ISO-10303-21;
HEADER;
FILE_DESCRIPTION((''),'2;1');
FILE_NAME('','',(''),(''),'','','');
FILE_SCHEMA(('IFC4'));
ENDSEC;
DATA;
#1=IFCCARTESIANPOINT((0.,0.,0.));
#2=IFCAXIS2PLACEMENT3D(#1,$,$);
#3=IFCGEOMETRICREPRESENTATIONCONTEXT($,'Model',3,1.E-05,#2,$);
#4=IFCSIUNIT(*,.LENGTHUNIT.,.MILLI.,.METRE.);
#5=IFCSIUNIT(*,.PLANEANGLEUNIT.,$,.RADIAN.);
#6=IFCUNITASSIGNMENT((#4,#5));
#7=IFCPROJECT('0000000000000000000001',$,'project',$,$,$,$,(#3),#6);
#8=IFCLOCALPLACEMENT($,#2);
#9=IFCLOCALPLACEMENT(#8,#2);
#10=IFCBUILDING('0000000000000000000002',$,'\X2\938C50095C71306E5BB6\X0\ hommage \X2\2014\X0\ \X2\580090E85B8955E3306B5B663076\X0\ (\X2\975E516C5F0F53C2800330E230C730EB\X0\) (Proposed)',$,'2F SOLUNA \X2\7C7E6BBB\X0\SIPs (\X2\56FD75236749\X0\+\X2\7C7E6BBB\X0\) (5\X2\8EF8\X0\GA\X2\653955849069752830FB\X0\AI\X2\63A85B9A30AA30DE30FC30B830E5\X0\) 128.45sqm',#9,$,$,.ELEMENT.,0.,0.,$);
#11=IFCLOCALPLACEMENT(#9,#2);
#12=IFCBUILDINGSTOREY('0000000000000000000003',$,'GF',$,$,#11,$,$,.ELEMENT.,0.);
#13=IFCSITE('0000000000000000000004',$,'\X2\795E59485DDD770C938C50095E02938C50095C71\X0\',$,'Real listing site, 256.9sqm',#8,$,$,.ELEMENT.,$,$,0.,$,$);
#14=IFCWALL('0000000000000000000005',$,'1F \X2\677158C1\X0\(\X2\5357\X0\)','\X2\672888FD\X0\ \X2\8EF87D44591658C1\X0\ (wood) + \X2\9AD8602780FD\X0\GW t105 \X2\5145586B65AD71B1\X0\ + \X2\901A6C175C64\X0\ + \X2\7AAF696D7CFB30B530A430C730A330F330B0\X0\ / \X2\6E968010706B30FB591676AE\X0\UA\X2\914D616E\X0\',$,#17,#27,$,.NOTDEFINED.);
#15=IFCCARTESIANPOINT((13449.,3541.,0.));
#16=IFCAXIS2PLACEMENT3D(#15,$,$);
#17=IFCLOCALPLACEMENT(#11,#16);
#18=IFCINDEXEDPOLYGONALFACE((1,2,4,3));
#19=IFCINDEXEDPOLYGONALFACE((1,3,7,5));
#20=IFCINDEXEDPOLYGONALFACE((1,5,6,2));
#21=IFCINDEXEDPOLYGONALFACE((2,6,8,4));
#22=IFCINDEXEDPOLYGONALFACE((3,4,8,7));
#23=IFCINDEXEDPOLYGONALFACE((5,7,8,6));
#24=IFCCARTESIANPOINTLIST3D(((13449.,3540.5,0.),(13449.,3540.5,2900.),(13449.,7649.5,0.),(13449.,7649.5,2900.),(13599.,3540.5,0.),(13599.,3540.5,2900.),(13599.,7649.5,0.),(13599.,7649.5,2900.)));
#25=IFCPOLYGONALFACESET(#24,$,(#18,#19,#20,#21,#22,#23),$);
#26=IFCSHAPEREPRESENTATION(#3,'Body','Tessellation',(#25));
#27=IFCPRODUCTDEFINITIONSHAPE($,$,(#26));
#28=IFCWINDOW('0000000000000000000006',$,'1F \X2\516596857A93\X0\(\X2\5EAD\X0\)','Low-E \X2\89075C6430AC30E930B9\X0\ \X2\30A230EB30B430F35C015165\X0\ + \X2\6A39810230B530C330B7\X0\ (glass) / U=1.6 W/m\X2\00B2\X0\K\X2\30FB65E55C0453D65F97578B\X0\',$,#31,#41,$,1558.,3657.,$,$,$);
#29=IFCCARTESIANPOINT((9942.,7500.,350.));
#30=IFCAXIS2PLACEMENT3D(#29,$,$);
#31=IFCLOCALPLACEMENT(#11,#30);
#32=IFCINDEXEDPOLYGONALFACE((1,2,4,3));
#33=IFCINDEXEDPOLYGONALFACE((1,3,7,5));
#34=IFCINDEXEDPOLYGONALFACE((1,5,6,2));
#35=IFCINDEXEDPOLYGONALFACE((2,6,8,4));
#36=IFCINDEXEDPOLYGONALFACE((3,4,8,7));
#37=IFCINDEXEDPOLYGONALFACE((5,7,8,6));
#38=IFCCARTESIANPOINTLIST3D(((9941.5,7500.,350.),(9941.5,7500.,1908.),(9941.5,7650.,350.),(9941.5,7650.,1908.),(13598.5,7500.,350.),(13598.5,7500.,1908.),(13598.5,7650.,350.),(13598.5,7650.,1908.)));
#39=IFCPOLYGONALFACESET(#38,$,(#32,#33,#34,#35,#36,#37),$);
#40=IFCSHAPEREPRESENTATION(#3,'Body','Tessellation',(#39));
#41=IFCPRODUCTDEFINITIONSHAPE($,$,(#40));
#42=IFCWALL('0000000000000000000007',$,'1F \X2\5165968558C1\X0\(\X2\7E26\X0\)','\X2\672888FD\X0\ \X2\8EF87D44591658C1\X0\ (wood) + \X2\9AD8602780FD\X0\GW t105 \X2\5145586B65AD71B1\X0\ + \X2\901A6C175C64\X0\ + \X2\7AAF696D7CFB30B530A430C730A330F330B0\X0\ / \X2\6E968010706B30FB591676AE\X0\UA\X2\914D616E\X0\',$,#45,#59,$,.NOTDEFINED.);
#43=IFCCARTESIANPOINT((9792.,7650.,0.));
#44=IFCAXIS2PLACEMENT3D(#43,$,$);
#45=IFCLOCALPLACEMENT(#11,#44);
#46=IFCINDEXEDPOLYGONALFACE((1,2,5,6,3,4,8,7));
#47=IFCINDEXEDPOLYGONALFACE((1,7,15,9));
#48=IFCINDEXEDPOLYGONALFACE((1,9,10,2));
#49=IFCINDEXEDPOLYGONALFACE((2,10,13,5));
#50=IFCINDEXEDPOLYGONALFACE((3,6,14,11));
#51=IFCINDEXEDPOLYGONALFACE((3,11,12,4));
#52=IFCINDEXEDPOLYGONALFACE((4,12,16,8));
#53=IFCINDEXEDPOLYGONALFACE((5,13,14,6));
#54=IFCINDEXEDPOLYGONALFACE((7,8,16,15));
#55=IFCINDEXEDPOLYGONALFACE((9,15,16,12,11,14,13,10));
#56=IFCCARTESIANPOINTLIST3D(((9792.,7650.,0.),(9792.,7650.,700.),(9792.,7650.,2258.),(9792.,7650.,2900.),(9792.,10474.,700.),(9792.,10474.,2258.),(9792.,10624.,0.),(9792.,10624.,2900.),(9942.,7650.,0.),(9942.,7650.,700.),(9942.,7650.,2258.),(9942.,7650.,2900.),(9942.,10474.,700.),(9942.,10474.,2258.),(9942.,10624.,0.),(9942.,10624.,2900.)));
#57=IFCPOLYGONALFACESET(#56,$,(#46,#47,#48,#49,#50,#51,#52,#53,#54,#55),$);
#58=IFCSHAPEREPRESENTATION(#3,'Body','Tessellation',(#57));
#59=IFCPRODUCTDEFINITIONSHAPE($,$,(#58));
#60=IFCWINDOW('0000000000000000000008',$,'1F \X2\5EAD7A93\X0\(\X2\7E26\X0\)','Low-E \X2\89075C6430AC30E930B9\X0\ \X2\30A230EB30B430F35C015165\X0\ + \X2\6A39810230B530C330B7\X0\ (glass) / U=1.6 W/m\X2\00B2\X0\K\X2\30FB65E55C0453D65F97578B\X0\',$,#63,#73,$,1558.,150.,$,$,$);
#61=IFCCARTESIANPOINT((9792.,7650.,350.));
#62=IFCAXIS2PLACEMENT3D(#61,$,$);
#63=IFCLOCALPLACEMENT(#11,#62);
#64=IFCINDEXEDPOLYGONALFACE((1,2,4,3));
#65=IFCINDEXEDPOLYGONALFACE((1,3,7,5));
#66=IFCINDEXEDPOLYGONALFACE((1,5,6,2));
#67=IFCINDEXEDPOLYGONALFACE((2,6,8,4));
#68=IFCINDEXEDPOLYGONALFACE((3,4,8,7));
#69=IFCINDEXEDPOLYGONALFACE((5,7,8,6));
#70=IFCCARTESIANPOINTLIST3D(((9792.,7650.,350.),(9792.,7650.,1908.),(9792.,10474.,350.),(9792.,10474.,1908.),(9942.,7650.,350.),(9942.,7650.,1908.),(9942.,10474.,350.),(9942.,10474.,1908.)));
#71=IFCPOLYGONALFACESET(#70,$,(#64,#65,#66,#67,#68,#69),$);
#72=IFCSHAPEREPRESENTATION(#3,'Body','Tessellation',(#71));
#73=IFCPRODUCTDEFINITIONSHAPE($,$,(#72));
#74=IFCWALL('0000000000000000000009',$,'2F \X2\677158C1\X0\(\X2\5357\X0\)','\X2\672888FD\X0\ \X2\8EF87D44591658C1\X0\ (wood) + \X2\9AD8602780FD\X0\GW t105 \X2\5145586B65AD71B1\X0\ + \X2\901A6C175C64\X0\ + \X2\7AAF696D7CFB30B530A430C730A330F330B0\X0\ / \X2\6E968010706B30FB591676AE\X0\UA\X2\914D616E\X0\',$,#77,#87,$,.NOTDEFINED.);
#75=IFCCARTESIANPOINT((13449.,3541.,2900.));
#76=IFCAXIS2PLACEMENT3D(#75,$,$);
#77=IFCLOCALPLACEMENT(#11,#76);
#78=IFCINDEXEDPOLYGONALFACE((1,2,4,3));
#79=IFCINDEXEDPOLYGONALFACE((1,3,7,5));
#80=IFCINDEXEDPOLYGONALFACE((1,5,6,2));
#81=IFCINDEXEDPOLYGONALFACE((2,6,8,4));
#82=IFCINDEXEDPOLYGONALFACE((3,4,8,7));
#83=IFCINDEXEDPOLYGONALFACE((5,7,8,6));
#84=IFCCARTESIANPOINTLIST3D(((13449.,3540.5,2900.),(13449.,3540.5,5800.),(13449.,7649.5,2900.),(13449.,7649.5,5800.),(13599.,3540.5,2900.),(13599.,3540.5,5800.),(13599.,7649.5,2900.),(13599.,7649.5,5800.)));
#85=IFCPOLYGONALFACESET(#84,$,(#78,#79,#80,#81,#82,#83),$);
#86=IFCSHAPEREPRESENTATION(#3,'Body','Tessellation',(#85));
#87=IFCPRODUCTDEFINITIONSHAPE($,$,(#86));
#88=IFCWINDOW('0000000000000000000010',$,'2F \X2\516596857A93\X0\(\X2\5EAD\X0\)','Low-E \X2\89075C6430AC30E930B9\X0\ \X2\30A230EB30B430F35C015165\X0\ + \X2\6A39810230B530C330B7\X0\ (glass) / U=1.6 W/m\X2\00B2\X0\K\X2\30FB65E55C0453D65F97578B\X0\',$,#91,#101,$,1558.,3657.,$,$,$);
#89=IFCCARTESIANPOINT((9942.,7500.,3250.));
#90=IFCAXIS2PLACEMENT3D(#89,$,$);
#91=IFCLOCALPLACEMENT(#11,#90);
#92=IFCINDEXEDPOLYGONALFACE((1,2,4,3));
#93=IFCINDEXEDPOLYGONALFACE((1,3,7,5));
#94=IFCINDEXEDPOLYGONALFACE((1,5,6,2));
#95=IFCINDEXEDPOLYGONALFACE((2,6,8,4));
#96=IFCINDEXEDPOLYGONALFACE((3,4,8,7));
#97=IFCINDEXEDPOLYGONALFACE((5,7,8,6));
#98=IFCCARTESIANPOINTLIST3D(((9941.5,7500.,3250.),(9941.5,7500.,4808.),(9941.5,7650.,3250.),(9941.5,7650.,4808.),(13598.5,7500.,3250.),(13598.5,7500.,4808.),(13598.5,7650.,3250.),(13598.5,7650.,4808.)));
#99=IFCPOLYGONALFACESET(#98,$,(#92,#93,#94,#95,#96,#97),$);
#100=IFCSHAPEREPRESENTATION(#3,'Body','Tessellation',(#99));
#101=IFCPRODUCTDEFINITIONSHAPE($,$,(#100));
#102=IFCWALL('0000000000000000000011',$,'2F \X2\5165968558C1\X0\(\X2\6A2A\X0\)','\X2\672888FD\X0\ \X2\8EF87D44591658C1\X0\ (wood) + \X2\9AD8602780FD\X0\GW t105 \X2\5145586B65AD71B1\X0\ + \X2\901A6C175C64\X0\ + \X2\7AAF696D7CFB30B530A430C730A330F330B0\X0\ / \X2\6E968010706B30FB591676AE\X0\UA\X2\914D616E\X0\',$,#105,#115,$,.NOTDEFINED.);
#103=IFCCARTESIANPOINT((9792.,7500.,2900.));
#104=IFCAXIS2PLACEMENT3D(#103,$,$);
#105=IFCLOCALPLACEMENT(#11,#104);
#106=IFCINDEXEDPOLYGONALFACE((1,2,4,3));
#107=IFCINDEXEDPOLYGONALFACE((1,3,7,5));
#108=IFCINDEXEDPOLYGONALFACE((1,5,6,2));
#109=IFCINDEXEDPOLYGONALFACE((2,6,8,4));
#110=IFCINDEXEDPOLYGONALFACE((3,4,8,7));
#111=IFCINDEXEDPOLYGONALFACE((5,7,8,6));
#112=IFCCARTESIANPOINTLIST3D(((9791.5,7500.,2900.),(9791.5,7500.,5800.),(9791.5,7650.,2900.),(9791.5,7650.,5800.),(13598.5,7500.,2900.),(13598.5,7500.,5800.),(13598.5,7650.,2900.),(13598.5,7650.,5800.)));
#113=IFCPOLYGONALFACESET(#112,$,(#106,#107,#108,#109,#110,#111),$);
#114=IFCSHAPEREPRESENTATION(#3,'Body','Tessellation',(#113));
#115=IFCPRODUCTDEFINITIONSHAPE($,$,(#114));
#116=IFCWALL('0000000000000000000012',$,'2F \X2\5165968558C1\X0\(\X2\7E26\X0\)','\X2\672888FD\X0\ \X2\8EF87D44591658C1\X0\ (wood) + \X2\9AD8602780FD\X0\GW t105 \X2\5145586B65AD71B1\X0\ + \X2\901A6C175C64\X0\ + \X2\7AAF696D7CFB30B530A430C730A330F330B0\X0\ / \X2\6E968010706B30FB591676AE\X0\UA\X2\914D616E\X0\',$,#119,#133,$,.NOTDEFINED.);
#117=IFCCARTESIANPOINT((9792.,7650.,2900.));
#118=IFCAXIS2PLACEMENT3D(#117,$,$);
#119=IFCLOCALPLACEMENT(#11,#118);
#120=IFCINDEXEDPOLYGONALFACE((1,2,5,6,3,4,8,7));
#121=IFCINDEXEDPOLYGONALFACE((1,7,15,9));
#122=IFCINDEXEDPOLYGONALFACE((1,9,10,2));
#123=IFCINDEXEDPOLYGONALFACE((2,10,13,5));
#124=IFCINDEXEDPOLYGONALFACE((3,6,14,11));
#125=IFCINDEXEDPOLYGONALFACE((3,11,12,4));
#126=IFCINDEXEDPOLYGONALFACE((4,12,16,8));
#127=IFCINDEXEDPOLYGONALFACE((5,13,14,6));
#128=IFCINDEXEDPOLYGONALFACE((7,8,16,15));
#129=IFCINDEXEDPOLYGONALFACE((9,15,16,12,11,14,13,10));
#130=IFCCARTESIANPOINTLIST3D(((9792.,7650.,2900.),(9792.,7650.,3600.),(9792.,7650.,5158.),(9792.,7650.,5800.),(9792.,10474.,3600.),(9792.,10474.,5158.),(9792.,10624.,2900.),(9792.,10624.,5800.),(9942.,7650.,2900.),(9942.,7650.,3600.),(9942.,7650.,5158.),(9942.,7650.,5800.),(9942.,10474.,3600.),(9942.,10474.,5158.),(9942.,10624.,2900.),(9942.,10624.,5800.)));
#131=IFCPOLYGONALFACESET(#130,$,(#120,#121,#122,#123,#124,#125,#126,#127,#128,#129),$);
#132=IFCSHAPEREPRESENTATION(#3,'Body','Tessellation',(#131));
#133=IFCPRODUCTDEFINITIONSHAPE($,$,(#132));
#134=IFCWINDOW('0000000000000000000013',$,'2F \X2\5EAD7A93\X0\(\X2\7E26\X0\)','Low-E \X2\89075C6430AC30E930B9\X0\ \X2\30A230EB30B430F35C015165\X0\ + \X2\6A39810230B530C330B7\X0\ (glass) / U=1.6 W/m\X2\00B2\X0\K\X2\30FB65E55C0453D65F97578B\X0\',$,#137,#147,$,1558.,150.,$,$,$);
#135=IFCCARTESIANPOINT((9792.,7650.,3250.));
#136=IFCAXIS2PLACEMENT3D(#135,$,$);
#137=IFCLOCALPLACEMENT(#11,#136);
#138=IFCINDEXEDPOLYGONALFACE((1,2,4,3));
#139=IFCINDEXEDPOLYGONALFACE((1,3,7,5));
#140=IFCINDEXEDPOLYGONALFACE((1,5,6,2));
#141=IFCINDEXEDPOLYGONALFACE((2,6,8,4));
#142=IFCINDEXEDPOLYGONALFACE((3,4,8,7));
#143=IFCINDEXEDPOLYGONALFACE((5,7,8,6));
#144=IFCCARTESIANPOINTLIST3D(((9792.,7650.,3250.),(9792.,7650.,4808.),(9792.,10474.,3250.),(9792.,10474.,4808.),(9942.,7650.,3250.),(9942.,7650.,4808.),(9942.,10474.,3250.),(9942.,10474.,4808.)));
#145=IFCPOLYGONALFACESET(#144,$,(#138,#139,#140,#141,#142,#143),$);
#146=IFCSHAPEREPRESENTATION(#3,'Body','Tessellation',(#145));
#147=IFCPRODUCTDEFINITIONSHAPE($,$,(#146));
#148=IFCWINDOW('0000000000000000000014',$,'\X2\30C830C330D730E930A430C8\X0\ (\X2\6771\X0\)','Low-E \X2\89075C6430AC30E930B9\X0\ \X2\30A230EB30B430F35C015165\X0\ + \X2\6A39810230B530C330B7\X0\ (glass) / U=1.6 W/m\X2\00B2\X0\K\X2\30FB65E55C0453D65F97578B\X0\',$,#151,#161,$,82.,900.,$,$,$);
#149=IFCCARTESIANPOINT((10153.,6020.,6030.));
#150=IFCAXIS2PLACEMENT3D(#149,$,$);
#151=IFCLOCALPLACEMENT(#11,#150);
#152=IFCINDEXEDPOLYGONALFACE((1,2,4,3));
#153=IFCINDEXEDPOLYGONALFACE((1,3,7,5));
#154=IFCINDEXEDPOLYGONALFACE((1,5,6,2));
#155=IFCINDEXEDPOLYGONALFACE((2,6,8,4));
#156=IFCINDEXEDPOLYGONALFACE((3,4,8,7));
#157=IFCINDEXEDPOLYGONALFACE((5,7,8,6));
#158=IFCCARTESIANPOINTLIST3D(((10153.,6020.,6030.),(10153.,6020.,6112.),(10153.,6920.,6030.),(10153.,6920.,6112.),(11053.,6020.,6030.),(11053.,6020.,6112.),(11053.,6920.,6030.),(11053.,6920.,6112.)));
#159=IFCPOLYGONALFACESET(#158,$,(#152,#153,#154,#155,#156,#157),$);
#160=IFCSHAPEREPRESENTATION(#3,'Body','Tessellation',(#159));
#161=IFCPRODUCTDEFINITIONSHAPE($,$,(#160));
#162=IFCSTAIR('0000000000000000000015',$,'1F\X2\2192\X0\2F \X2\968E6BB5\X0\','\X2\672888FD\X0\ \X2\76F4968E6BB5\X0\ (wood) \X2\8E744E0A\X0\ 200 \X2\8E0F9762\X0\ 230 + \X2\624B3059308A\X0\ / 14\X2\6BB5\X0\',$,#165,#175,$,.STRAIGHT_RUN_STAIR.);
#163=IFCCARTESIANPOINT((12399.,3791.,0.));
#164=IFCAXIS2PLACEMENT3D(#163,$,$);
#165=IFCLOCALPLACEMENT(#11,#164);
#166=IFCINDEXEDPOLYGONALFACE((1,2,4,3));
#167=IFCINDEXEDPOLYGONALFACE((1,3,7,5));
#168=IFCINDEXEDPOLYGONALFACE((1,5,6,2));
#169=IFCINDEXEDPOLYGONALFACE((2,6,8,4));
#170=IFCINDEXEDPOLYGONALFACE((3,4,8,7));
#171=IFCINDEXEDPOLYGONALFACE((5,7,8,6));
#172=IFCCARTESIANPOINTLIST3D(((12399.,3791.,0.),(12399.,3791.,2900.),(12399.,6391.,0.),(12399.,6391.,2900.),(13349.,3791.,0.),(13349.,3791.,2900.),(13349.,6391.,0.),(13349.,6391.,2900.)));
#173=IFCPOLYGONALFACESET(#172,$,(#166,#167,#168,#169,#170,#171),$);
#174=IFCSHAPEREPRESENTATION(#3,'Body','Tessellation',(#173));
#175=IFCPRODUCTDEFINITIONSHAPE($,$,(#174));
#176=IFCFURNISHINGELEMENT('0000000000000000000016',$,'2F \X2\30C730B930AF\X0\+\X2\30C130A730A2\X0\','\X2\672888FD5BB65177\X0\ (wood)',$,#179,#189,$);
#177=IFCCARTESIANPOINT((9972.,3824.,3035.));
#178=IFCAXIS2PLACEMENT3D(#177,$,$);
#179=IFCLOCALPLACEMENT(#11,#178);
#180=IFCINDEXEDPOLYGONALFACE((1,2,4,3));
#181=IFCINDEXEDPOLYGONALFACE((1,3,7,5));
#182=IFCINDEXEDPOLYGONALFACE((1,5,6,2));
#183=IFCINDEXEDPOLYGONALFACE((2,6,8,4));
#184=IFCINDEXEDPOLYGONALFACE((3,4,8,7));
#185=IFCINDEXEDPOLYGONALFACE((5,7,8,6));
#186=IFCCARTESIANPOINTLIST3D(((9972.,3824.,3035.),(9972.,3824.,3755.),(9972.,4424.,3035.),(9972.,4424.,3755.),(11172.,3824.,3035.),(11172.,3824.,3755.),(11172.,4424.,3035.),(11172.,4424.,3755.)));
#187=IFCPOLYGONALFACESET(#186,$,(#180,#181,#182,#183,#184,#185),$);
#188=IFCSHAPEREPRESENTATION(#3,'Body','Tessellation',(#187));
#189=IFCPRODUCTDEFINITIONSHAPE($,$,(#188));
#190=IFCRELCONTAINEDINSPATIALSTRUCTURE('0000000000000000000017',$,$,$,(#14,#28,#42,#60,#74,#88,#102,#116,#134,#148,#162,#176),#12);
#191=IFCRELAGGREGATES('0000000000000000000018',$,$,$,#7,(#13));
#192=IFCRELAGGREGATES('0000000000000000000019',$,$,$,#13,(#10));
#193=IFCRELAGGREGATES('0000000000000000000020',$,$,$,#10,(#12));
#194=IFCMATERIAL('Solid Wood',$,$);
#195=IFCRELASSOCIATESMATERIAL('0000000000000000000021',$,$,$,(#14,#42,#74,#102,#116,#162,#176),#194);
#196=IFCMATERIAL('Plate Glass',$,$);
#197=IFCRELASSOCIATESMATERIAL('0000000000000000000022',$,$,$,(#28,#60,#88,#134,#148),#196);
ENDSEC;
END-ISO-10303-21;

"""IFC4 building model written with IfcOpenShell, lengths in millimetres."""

from ifc_helpers import new_model, si_unit, frame, frame_2d, origin, place, context, project, spatial, rectangle, extrude, material, element, fill, save


model = new_model("IFC4")

# Units and contexts
model_context = context("Model", 3, precision=1e-05, world=origin())
ifc_project = project(units=[si_unit("LENGTHUNIT", "METRE", prefix="MILLI"), si_unit("PLANEANGLEUNIT", "RADIAN")], contexts=[model_context])

# Site, building, storey
site_placement = place(None, origin())
site = spatial("IfcSite", under=ifc_project, at=site_placement, Name="神奈川県鎌倉市鎌倉山", ObjectType="Real listing site, 256.9sqm", CompositionType="ELEMENT", RefElevation=0.0)
building_placement = place(site_placement, origin())
building = spatial("IfcBuilding", under=site, at=building_placement, Name="鎌倉山の家 hommage — 堀部安嗣に学ぶ (非公式参考モデル) (Proposed)", ObjectType="2F SOLUNA 籾殻SIPs (国産杉+籾殻) (5軸GA改善適用・AI推定オマージュ) 128.45sqm", CompositionType="ELEMENT", ElevationOfRefHeight=0.0, ElevationOfTerrain=0.0)
storey_placement = place(building_placement, origin())
storey = spatial("IfcBuildingStorey", under=building, at=storey_placement, Name="GF", CompositionType="ELEMENT", Elevation=0.0)

# Shared definitions
ifc_material_1 = material(Name="Solid Wood")

# Wall, opening, window
wall_1_placement = place(storey_placement, frame((13449.0, 3541.0, 0.0)))
wall_1 = element("IfcWall", 1, at=wall_1_placement, inside=storey, material=ifc_material_1, Name="1F 東壁(南)", Description="木製 軸組外壁 (wood) + 高性能GW t105 充填断熱 + 通気層 + 窯業系サイディング / 準耐火・外皮UA配慮", PredefinedType="NOTDEFINED", context=model_context, shape_type="SweptSolid", body=[
    extrude(rectangle(XDim=150.0, YDim=4109.0, at=frame_2d((75.0, 2054.0))), frame((13449.0, 3541.0, 0.0)), (0.0, 0.0, 1.0), 2900.0),
])
opening_1_placement = place(storey_placement, frame((9942.0, 7500.0, 350.0)))
opening_1 = element("IfcOpeningElement", 2, at=opening_1_placement, cuts=wall_1, PredefinedType="NOTDEFINED", context=model_context, shape_type="SweptSolid", body=[
    extrude(rectangle(XDim=3657.0, YDim=150.0, at=frame_2d((1828.0, 75.0))), frame((9942.0, 7500.0, 350.0)), (0.0, 0.0, 1.0), 1558.0),
])
ifc_material_2 = material(Name="Plate Glass")
window_1_placement = place(storey_placement, frame((9942.0, 7500.0, 350.0)))
window_1 = element("IfcWindow", 3, at=window_1_placement, inside=storey, material=ifc_material_2, Name="1F 入隅窓(庭)", Description="Low-E 複層ガラス アルゴン封入 + 樹脂サッシ (glass) / U=1.6 W/m²K・日射取得型", OverallHeight=1558.0, OverallWidth=3657.0, context=model_context, shape_type="SweptSolid", body=[
    extrude(rectangle(XDim=3657.0, YDim=150.0, at=frame_2d((1828.0, 75.0))), frame((9942.0, 7500.0, 350.0)), (0.0, 0.0, 1.0), 1558.0),
])
fill(opening_1, window_1)

# Wall, opening, window
wall_2_placement = place(storey_placement, frame((9792.0, 7650.0, 0.0)))
wall_2 = element("IfcWall", 4, at=wall_2_placement, inside=storey, material=ifc_material_1, Name="1F 入隅壁(縦)", Description="木製 軸組外壁 (wood) + 高性能GW t105 充填断熱 + 通気層 + 窯業系サイディング / 準耐火・外皮UA配慮", PredefinedType="NOTDEFINED", context=model_context, shape_type="SweptSolid", body=[
    extrude(rectangle(XDim=150.0, YDim=2974.0, at=frame_2d((75.0, 1487.0))), frame((9792.0, 7650.0, 0.0)), (0.0, 0.0, 1.0), 2900.0),
])
opening_2_placement = place(storey_placement, frame((9792.0, 7650.0, 350.0)))
opening_2 = element("IfcOpeningElement", 5, at=opening_2_placement, cuts=wall_2, PredefinedType="NOTDEFINED", context=model_context, shape_type="SweptSolid", body=[
    extrude(rectangle(XDim=150.0, YDim=2824.0, at=frame_2d((75.0, 1412.0))), frame((9792.0, 7650.0, 350.0)), (0.0, 0.0, 1.0), 1558.0),
])
window_2_placement = place(storey_placement, frame((9792.0, 7650.0, 350.0)))
window_2 = element("IfcWindow", 6, at=window_2_placement, inside=storey, material=ifc_material_2, Name="1F 庭窓(縦)", Description="Low-E 複層ガラス アルゴン封入 + 樹脂サッシ (glass) / U=1.6 W/m²K・日射取得型", OverallHeight=1558.0, OverallWidth=150.0, context=model_context, shape_type="SweptSolid", body=[
    extrude(rectangle(XDim=150.0, YDim=2824.0, at=frame_2d((75.0, 1412.0))), frame((9792.0, 7650.0, 350.0)), (0.0, 0.0, 1.0), 1558.0),
])
fill(opening_2, window_2)

# Wall, opening, window
wall_3_placement = place(storey_placement, frame((13449.0, 3541.0, 2900.0)))
wall_3 = element("IfcWall", 7, at=wall_3_placement, inside=storey, material=ifc_material_1, Name="2F 東壁(南)", Description="木製 軸組外壁 (wood) + 高性能GW t105 充填断熱 + 通気層 + 窯業系サイディング / 準耐火・外皮UA配慮", PredefinedType="NOTDEFINED", context=model_context, shape_type="SweptSolid", body=[
    extrude(rectangle(XDim=150.0, YDim=4109.0, at=frame_2d((75.0, 2054.0))), frame((13449.0, 3541.0, 2900.0)), (0.0, 0.0, 1.0), 2900.0),
])
opening_3_placement = place(storey_placement, frame((9942.0, 7500.0, 3250.0)))
opening_3 = element("IfcOpeningElement", 8, at=opening_3_placement, cuts=wall_3, PredefinedType="NOTDEFINED", context=model_context, shape_type="SweptSolid", body=[
    extrude(rectangle(XDim=3657.0, YDim=150.0, at=frame_2d((1828.0, 75.0))), frame((9942.0, 7500.0, 3250.0)), (0.0, 0.0, 1.0), 1558.0),
])
window_3_placement = place(storey_placement, frame((9942.0, 7500.0, 3250.0)))
window_3 = element("IfcWindow", 9, at=window_3_placement, inside=storey, material=ifc_material_2, Name="2F 入隅窓(庭)", Description="Low-E 複層ガラス アルゴン封入 + 樹脂サッシ (glass) / U=1.6 W/m²K・日射取得型", OverallHeight=1558.0, OverallWidth=3657.0, context=model_context, shape_type="SweptSolid", body=[
    extrude(rectangle(XDim=3657.0, YDim=150.0, at=frame_2d((1828.0, 75.0))), frame((9942.0, 7500.0, 3250.0)), (0.0, 0.0, 1.0), 1558.0),
])
fill(opening_3, window_3)

# Wall
wall_4_placement = place(storey_placement, frame((9792.0, 7500.0, 2900.0)))
element("IfcWall", 10, at=wall_4_placement, inside=storey, material=ifc_material_1, Name="2F 入隅壁(横)", Description="木製 軸組外壁 (wood) + 高性能GW t105 充填断熱 + 通気層 + 窯業系サイディング / 準耐火・外皮UA配慮", PredefinedType="NOTDEFINED", context=model_context, shape_type="SweptSolid", body=[
    extrude(rectangle(XDim=3807.0, YDim=150.0, at=frame_2d((1903.0, 75.0))), frame((9792.0, 7500.0, 2900.0)), (0.0, 0.0, 1.0), 2900.0),
])

# Wall, opening, window
wall_5_placement = place(storey_placement, frame((9792.0, 7650.0, 2900.0)))
wall_5 = element("IfcWall", 11, at=wall_5_placement, inside=storey, material=ifc_material_1, Name="2F 入隅壁(縦)", Description="木製 軸組外壁 (wood) + 高性能GW t105 充填断熱 + 通気層 + 窯業系サイディング / 準耐火・外皮UA配慮", PredefinedType="NOTDEFINED", context=model_context, shape_type="SweptSolid", body=[
    extrude(rectangle(XDim=150.0, YDim=2974.0, at=frame_2d((75.0, 1487.0))), frame((9792.0, 7650.0, 2900.0)), (0.0, 0.0, 1.0), 2900.0),
])
opening_4_placement = place(storey_placement, frame((9792.0, 7650.0, 3250.0)))
opening_4 = element("IfcOpeningElement", 12, at=opening_4_placement, cuts=wall_5, PredefinedType="NOTDEFINED", context=model_context, shape_type="SweptSolid", body=[
    extrude(rectangle(XDim=150.0, YDim=2824.0, at=frame_2d((75.0, 1412.0))), frame((9792.0, 7650.0, 3250.0)), (0.0, 0.0, 1.0), 1558.0),
])
window_4_placement = place(storey_placement, frame((9792.0, 7650.0, 3250.0)))
window_4 = element("IfcWindow", 13, at=window_4_placement, inside=storey, material=ifc_material_2, Name="2F 庭窓(縦)", Description="Low-E 複層ガラス アルゴン封入 + 樹脂サッシ (glass) / U=1.6 W/m²K・日射取得型", OverallHeight=1558.0, OverallWidth=150.0, context=model_context, shape_type="SweptSolid", body=[
    extrude(rectangle(XDim=150.0, YDim=2824.0, at=frame_2d((75.0, 1412.0))), frame((9792.0, 7650.0, 3250.0)), (0.0, 0.0, 1.0), 1558.0),
])
fill(opening_4, window_4)

# Window
window_5_placement = place(storey_placement, frame((10153.0, 6020.0, 6030.0)))
element("IfcWindow", 14, at=window_5_placement, inside=storey, material=ifc_material_2, Name="トップライト (東)", Description="Low-E 複層ガラス アルゴン封入 + 樹脂サッシ (glass) / U=1.6 W/m²K・日射取得型", OverallHeight=82.0, OverallWidth=900.0, context=model_context, shape_type="SweptSolid", body=[
    extrude(rectangle(XDim=900.0, YDim=900.0, at=frame_2d((450.0, 450.0))), frame((10153.0, 6020.0, 6030.0)), (0.0, 0.0, 1.0), 82.0),
])

# Stair
stair_placement = place(storey_placement, frame((12399.0, 3791.0, 0.0)))
element("IfcStair", 15, at=stair_placement, inside=storey, material=ifc_material_1, Name="1F→2F 階段", Description="木製 直階段 (wood) 蹴上 200 踏面 230 + 手すり / 14段", PredefinedType="STRAIGHT_RUN_STAIR", context=model_context, shape_type="SweptSolid", body=[
    extrude(rectangle(XDim=950.0, YDim=2600.0, at=frame_2d((475.0, 1300.0))), frame((12399.0, 3791.0, 0.0)), (0.0, 0.0, 1.0), 2900.0),
])

# Furnishing element
furnishing_1_placement = place(storey_placement, frame((9972.0, 3824.0, 3035.0)))
element("IfcFurnishingElement", 16, at=furnishing_1_placement, inside=storey, material=ifc_material_1, Name="2F デスク+チェア", Description="木製家具 (wood)", context=model_context, shape_type="SweptSolid", body=[
    extrude(rectangle(XDim=1200.0, YDim=600.0, at=frame_2d((600.0, 300.0))), frame((9972.0, 3824.0, 3035.0)), (0.0, 0.0, 1.0), 720.0),
])

save(model, "model.ifc")
